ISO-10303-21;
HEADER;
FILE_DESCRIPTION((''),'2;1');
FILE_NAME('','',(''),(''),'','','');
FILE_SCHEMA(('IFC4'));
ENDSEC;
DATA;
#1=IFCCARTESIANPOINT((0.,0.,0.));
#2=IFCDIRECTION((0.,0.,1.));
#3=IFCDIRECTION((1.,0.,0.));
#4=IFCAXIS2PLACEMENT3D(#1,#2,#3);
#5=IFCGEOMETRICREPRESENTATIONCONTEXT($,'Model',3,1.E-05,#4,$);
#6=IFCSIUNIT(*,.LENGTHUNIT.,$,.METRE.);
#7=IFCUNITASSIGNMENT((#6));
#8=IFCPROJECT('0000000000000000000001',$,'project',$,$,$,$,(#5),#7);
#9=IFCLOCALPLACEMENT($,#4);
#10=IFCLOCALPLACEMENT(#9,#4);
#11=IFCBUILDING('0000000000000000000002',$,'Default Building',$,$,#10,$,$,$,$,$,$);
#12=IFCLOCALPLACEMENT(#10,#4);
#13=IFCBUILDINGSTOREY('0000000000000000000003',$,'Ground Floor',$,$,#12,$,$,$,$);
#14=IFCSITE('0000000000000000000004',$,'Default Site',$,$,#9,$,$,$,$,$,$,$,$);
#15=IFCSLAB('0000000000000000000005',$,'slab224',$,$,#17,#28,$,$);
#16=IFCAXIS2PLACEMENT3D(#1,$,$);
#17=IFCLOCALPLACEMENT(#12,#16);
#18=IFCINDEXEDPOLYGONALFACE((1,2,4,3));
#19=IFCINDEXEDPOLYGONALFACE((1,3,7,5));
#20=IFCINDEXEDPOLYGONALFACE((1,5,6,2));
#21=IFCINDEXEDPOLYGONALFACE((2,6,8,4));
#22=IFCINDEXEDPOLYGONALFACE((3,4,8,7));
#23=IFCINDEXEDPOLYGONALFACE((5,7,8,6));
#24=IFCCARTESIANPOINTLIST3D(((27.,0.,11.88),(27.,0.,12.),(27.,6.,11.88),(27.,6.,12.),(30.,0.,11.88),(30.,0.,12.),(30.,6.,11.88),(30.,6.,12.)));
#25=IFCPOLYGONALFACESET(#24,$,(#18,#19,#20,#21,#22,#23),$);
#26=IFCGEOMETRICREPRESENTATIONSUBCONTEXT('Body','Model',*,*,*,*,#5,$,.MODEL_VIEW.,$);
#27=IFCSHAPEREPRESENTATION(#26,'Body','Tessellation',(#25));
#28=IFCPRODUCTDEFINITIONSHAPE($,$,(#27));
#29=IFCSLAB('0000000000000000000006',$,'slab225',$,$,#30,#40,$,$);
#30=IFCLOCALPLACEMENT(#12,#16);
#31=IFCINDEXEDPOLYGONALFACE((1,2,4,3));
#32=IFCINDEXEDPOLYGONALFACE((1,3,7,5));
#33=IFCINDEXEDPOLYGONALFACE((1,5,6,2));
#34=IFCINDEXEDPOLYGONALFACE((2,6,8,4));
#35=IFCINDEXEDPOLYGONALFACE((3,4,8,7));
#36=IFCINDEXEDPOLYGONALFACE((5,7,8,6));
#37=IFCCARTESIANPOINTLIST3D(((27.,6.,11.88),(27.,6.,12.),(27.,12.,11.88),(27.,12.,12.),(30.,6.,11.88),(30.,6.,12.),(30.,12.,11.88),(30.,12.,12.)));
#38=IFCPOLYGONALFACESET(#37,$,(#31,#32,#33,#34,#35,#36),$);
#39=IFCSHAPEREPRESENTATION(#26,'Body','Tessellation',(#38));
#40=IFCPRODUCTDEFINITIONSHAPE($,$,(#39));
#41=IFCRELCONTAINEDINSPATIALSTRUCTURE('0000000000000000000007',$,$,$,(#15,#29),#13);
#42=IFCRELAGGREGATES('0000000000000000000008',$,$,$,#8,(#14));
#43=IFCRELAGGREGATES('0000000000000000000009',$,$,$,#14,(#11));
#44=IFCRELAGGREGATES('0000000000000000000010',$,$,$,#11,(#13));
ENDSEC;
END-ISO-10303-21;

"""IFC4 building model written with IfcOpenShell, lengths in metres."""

from ifc_helpers import new_model, si_unit, frame, origin_with_axes, place, context, subcontext, project, spatial, indexed_curve, outline, extrude, element, save


model = new_model("IFC4")

# Units and contexts
model_context = context("Model", 3, precision=1e-05, world=origin_with_axes())
body_context = subcontext(model_context, "Body", "Model", "MODEL_VIEW")
ifc_project = project(units=[si_unit("LENGTHUNIT", "METRE")], contexts=[model_context])

# Site, building, storey
site_placement = place(None, origin_with_axes())
site = spatial("IfcSite", under=ifc_project, at=site_placement, Name="Default Site")
building_placement = place(site_placement, origin_with_axes())
building = spatial("IfcBuilding", under=site, at=building_placement, Name="Default Building")
storey_placement = place(building_placement, origin_with_axes())
storey = spatial("IfcBuildingStorey", under=building, at=storey_placement, Name="Ground Floor")

# Slabs
for number, where, z_axis, x_axis, name in (
    (1, (27.0, 0.0, 11.88), (0.0, 0.0, 1.0), (1.0, 0.0, 0.0), "slab224"),
    (2, (27.0, 6.0, 11.88), (0.0, 0.0, 1.0), (1.0, 0.0, 0.0), "slab225"),
):
    element("IfcSlab", number, at=place(storey_placement, frame(where, z_axis=z_axis, x_axis=x_axis)), inside=storey, Name=name, context=body_context, shape_type="SweptSolid", body=[
        extrude(outline(indexed_curve([(0.0, 0.0), (0.0, 6.0), (3.0, 6.0), (3.0, 0.0), (0.0, 0.0)], self_intersect=False)), origin_with_axes(), (0.0, 0.0, 1.0), 0.12),
    ])

save(model, "model.ifc")
